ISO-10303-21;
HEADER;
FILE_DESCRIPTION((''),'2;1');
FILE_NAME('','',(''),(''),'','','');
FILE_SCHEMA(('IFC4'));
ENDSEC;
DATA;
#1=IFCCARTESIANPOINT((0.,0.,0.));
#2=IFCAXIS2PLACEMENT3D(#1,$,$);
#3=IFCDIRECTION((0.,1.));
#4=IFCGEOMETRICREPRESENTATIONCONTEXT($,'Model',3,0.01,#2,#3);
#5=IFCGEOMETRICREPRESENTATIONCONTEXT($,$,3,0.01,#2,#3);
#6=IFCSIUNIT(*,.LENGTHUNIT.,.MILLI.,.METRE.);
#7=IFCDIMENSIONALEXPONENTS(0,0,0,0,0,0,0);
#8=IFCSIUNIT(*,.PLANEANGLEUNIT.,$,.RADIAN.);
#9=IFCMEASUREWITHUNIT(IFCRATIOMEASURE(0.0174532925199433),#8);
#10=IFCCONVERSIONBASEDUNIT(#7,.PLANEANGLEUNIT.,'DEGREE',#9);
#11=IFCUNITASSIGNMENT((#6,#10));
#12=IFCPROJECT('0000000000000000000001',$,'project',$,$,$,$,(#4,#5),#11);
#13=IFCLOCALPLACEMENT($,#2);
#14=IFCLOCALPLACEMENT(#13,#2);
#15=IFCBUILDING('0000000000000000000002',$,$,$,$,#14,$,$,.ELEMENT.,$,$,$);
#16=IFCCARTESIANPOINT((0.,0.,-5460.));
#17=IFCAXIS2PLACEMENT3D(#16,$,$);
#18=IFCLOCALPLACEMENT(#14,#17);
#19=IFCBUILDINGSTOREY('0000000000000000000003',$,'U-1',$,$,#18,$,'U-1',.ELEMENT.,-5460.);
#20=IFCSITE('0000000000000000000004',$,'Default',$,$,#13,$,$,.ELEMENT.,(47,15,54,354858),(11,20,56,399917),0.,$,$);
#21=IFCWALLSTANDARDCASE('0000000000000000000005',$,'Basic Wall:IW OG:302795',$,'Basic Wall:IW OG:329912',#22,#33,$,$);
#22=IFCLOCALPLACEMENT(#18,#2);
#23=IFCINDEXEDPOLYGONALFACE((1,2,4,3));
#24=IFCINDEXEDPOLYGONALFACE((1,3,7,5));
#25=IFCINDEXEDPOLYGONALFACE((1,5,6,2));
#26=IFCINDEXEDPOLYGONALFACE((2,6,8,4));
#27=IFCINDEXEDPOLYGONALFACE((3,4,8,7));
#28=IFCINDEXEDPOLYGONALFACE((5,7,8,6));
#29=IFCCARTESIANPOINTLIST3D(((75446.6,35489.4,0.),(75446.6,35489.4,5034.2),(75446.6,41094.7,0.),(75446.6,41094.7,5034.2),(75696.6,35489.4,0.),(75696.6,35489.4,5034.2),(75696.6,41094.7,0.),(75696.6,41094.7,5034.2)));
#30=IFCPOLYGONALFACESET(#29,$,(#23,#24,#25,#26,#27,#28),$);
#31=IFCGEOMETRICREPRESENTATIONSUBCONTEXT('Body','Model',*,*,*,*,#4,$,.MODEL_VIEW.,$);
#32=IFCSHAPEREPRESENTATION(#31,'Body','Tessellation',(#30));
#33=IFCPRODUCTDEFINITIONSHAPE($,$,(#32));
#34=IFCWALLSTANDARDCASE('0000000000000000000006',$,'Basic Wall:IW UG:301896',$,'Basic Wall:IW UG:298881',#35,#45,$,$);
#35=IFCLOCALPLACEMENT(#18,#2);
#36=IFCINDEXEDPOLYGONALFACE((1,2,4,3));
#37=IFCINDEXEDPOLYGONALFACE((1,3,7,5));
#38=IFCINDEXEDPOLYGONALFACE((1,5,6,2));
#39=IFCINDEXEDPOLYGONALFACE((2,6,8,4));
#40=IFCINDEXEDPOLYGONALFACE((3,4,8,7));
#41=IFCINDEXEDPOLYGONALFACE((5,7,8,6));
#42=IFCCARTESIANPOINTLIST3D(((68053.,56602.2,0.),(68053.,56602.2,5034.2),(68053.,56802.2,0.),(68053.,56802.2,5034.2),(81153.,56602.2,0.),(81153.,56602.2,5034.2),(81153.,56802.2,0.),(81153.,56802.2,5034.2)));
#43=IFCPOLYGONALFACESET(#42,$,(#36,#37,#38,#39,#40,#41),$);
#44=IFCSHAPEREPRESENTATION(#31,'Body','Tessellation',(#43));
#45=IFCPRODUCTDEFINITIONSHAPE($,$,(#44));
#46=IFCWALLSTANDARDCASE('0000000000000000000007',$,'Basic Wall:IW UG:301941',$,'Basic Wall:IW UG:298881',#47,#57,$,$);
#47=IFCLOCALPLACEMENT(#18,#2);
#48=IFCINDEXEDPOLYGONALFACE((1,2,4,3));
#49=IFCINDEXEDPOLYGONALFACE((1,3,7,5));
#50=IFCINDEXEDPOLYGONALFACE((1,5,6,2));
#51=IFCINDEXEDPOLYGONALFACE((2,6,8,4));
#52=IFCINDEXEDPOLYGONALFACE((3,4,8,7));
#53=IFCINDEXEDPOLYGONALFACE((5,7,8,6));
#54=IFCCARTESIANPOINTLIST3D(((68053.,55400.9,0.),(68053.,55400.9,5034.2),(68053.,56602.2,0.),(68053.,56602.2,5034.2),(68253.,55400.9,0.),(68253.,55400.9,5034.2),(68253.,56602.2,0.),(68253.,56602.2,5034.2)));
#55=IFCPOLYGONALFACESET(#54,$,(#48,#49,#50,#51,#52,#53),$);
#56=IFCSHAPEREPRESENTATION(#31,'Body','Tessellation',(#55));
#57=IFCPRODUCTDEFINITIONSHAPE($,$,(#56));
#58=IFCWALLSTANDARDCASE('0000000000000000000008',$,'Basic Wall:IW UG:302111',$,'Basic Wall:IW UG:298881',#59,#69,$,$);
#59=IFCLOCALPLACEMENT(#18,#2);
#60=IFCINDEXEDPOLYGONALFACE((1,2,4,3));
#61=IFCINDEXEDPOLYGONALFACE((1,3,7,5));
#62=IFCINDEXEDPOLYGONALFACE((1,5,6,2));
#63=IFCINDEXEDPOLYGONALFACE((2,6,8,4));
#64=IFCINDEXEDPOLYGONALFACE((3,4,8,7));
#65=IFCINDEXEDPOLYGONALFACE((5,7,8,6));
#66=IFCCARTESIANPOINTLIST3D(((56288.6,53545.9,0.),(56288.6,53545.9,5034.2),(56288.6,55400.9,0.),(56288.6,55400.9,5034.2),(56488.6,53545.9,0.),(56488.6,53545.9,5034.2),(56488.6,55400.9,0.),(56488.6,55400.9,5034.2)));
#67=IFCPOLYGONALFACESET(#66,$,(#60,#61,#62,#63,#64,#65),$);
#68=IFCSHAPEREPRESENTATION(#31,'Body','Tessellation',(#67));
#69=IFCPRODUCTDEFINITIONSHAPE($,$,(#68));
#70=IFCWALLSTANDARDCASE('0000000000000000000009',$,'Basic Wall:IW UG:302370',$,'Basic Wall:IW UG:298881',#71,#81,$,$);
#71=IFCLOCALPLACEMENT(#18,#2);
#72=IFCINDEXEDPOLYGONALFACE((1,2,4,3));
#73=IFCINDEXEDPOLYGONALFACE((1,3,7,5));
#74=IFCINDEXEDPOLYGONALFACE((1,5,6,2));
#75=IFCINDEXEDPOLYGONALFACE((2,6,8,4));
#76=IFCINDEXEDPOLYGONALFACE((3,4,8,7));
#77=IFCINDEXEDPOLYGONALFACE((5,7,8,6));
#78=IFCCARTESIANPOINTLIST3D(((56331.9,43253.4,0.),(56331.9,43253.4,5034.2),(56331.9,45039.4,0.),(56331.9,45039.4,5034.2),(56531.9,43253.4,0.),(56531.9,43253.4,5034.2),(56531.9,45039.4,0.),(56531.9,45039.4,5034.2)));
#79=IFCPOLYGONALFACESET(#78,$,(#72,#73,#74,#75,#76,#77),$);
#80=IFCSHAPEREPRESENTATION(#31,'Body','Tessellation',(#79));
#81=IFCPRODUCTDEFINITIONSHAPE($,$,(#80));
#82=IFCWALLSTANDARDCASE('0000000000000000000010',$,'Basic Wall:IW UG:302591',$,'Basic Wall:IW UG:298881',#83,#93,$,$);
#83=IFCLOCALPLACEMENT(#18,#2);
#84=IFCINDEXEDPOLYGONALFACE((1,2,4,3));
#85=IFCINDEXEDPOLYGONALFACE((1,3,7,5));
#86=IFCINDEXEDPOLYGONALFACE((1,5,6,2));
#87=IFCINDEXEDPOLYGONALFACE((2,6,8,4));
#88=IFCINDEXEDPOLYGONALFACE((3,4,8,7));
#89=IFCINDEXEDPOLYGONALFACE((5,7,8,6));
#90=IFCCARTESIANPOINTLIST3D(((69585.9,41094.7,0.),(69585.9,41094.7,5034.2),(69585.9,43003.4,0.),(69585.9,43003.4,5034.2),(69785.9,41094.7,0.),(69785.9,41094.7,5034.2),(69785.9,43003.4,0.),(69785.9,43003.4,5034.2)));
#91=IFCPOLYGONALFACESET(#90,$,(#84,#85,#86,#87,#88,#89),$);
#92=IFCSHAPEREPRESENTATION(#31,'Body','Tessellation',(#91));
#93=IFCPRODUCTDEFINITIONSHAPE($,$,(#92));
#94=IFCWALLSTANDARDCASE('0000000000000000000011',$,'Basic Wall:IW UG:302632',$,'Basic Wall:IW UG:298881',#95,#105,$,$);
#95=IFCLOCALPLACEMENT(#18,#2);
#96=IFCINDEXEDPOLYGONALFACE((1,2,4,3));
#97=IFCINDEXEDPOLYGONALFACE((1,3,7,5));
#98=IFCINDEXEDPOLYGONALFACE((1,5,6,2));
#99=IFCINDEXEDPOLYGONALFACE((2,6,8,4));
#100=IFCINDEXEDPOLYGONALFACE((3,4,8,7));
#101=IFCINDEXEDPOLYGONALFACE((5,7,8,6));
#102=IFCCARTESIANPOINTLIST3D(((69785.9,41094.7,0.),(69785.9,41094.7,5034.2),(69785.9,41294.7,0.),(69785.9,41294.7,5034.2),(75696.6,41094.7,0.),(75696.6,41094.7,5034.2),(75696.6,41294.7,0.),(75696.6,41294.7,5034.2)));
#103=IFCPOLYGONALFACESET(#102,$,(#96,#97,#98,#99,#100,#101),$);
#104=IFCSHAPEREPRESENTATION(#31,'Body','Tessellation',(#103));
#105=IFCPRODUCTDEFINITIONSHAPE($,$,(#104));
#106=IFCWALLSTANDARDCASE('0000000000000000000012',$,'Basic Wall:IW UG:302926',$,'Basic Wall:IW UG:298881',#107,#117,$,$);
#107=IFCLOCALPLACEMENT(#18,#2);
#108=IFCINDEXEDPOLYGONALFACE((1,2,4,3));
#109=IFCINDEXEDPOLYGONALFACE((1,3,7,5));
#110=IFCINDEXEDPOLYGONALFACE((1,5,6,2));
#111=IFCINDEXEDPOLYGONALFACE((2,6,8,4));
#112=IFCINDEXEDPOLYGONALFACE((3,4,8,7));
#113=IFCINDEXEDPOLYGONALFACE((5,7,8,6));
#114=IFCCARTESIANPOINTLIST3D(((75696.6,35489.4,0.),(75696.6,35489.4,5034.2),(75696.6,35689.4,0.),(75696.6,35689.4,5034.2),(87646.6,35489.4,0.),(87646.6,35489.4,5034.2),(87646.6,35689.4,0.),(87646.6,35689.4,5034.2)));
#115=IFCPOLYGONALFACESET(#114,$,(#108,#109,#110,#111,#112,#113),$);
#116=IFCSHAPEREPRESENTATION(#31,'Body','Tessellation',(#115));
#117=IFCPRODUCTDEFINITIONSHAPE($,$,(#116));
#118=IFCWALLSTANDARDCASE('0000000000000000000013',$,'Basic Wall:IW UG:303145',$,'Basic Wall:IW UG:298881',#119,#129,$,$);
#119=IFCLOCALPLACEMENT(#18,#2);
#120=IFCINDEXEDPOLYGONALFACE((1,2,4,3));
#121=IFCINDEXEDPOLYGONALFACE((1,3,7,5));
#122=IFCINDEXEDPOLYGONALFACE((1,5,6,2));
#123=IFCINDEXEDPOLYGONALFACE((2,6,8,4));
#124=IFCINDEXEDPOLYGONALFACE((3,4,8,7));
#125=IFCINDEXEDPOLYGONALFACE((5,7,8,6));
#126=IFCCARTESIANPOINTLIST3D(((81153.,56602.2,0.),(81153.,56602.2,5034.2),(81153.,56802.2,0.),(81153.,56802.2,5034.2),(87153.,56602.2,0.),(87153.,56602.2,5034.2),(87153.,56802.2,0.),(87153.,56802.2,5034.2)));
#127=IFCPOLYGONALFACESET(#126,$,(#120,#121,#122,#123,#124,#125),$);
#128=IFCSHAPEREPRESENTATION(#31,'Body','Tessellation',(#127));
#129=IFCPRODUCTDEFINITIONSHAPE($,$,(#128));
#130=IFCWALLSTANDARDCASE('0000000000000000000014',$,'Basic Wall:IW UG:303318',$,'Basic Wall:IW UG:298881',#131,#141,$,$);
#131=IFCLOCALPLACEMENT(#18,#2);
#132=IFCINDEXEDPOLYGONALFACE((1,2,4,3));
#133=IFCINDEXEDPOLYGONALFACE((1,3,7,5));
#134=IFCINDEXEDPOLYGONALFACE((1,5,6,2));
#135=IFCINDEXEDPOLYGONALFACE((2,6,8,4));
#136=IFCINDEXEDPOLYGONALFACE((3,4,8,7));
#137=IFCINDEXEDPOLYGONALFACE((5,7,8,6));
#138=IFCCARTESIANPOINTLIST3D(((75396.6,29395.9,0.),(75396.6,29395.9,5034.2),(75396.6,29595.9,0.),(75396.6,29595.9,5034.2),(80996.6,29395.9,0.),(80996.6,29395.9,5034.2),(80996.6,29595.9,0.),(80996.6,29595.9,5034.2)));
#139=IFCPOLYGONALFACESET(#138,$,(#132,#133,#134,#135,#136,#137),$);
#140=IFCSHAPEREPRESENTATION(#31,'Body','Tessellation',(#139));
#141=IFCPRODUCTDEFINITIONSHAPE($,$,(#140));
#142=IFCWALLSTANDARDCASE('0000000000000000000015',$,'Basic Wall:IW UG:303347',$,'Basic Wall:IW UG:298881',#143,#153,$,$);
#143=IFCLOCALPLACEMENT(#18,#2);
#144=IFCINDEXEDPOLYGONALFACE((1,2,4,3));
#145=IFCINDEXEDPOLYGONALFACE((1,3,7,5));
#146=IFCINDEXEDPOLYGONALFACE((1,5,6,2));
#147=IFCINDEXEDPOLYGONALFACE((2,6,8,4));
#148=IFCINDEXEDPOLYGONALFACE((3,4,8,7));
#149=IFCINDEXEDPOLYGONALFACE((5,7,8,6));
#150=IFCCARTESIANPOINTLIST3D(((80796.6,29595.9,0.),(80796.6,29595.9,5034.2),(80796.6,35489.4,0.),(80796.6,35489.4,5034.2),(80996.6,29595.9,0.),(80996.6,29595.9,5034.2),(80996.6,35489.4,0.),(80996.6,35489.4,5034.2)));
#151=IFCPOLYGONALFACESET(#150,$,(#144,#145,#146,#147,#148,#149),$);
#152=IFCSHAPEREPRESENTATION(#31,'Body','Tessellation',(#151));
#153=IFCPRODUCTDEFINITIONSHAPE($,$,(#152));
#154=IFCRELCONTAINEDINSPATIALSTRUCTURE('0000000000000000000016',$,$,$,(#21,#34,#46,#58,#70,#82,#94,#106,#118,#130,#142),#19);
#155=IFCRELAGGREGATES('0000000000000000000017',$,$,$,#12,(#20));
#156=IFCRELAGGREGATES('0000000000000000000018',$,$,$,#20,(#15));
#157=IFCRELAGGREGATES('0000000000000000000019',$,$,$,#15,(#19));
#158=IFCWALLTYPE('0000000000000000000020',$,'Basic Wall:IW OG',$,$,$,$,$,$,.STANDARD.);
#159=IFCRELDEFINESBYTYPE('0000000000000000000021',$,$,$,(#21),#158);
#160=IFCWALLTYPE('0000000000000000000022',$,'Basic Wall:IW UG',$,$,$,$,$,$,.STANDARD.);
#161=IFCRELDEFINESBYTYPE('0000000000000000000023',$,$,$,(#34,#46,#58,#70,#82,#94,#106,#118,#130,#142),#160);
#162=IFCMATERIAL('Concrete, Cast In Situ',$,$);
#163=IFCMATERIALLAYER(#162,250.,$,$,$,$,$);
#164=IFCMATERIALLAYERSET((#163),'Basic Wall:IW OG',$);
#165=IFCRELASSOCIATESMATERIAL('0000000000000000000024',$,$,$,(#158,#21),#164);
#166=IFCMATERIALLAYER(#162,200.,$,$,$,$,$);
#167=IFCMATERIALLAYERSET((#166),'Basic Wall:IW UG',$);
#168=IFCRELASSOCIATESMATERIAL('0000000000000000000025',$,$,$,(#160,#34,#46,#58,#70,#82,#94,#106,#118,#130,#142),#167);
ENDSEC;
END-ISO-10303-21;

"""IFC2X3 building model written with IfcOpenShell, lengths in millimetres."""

from ifc_helpers import new_model, entity, si_unit, converted_unit, direction, frame, frame_2d, origin, place, context, subcontext, project, spatial, polyline, rectangle, extrude, clip, bounded_halfspace, material, layer, layer_set, layer_usage, type_object, element, save


model = new_model("IFC2X3")

# Units and contexts
model_context = context("Model", 3, precision=0.01, world=origin(), true_north=direction((0.0, 1.0)))
context_of_model = context(None, 3, precision=0.01, world=origin(), true_north=direction((0.0, 1.0)))
body_context = subcontext(model_context, "Body", "Model", "MODEL_VIEW")
ifc_project = project(units=[si_unit("LENGTHUNIT", "METRE", prefix="MILLI"), converted_unit("PLANEANGLEUNIT", "DEGREE", entity("IfcRatioMeasure", 0.0174532925199433), si_unit("PLANEANGLEUNIT", "RADIAN"), dimensions=[0, 0, 0, 0, 0, 0, 0])], contexts=[model_context, context_of_model])

# Site, building, storey
site_placement = place(None, origin())
site = spatial("IfcSite", under=ifc_project, at=site_placement, Name="Default", CompositionType="ELEMENT", RefLatitude=(47, 15, 54, 354858), RefLongitude=(11, 20, 56, 399917), RefElevation=0.0)
building_placement = place(site_placement, origin())
building = spatial("IfcBuilding", under=site, at=building_placement, CompositionType="ELEMENT")
storey_placement = place(building_placement, frame((0.0, 0.0, -5460.0)))
storey = spatial("IfcBuildingStorey", under=building, at=storey_placement, Name="U-1", LongName="U-1", CompositionType="ELEMENT", Elevation=-5460.0)

# Walls
ifc_material_1 = material(Name="Concrete, Cast In Situ")
ifc_layer_1 = layer(ifc_material_1, 250.0)
ifc_layer_set_1 = layer_set([ifc_layer_1], Name="Basic Wall:IW OG")
wall_type_1 = type_object("IfcWallType", Name="Basic Wall:IW OG", PredefinedType="STANDARD", material=ifc_layer_set_1)
ifc_layer_usage_1 = layer_usage(ifc_layer_set_1, "AXIS2", "NEGATIVE", 125.0)
wall_1_placement = place(storey_placement, frame((75571.6, 41094.7, 0.0), z_axis=(0.0, 0.0, 1.0), x_axis=(0.0, -1.0, 0.0)))
element("IfcWallStandardCase", 1, at=wall_1_placement, inside=storey, type_object=wall_type_1, material=ifc_layer_usage_1, Name="Basic Wall:IW OG:302795", ObjectType="Basic Wall:IW OG:329912", context=body_context, shape_type="Clipping", body=[
    clip(extrude(rectangle(XDim=5605.2, YDim=250.0, at=frame_2d((2802.6, 0.0), x_axis=(-1.0, 0.0))), origin(), (0.0, 0.0, 1.0), 5034.2), bounded_halfspace(frame((0.0, -125.0, 5034.2), z_axis=(0.0, 0.0, -1.0), x_axis=(0.0, 1.0, 0.0)), True, frame((0.0, -125.0, 5034.2)), polyline([(0.0, 0.0), (5605.2, 0.0), (5605.2, 250.0), (5405.2, 250.0), (0.0, 250.0), (0.0, 0.0)]))),
])
ifc_layer_2 = layer(ifc_material_1, 200.0)
ifc_layer_set_2 = layer_set([ifc_layer_2], Name="Basic Wall:IW UG")
ifc_layer_usage_2 = layer_usage(ifc_layer_set_2, "AXIS2", "NEGATIVE", 100.0)
wall_type_2 = type_object("IfcWallType", Name="Basic Wall:IW UG", PredefinedType="STANDARD", material=ifc_layer_set_2)
wall_2_placement = place(storey_placement, frame((81153.0, 56702.2, 0.0), z_axis=(0.0, 0.0, 1.0), x_axis=(-1.0, 0.0, 0.0)))
element("IfcWallStandardCase", 2, at=wall_2_placement, inside=storey, type_object=wall_type_2, material=ifc_layer_usage_2, Name="Basic Wall:IW UG:301896", ObjectType="Basic Wall:IW UG:298881", context=body_context, shape_type="Clipping", body=[
    clip(extrude(rectangle(XDim=13100.0, YDim=200.0, at=frame_2d((6550.0, 0.0), x_axis=(-1.0, 0.0))), origin(), (0.0, 0.0, 1.0), 5034.2), bounded_halfspace(frame((0.0, -100.0, 5034.2), z_axis=(0.0, 0.0, -1.0), x_axis=(-1.0, 0.0, 0.0)), True, frame((0.0, -100.0, 5034.2)), polyline([(0.0, 0.0), (13100.0, 0.0), (13100.0, 200.0), (12900.0, 200.0), (5460.0, 200.0), (0.0, 200.0), (0.0, 0.0)]))),
])
ifc_layer_usage_3 = layer_usage(ifc_layer_set_2, "AXIS2", "NEGATIVE", 100.0)
wall_3_placement = place(storey_placement, frame((68153.0, 56602.2, 0.0), z_axis=(0.0, 0.0, 1.0), x_axis=(0.0, -1.0, 0.0)))
element("IfcWallStandardCase", 3, at=wall_3_placement, inside=storey, type_object=wall_type_2, material=ifc_layer_usage_3, Name="Basic Wall:IW UG:301941", ObjectType="Basic Wall:IW UG:298881", context=body_context, shape_type="Clipping", body=[
    clip(extrude(rectangle(XDim=1201.4, YDim=200.0, at=frame_2d((600.7, 0.0), x_axis=(-1.0, 0.0))), origin(), (0.0, 0.0, 1.0), 5034.2), bounded_halfspace(frame((0.0, -100.0, 5034.2), z_axis=(0.0, 0.0, -1.0), x_axis=(0.0, 1.0, 0.0)), True, frame((0.0, -100.0, 5034.2)), polyline([(0.0, 0.0), (951.4, 0.0), (1201.4, 0.0), (1201.4, 200.0), (0.0, 200.0), (0.0, 0.0)]))),
])
ifc_layer_usage_4 = layer_usage(ifc_layer_set_2, "AXIS2", "NEGATIVE", 100.0)
wall_4_placement = place(storey_placement, frame((56388.6, 55400.9, 0.0), z_axis=(0.0, 0.0, 1.0), x_axis=(0.0, -1.0, 0.0)))
element("IfcWallStandardCase", 4, at=wall_4_placement, inside=storey, type_object=wall_type_2, material=ifc_layer_usage_4, Name="Basic Wall:IW UG:302111", ObjectType="Basic Wall:IW UG:298881", context=body_context, shape_type="Clipping", body=[
    clip(extrude(rectangle(XDim=1855.0, YDim=200.0, at=frame_2d((927.5, 0.0), x_axis=(-1.0, 0.0))), origin(), (0.0, 0.0, 1.0), 5034.2), bounded_halfspace(frame((0.0, -100.0, 5034.2), z_axis=(0.0, 0.0, -1.0), x_axis=(0.0, 1.0, 0.0)), True, frame((0.0, -100.0, 5034.2)), polyline([(0.0, 0.0), (1655.0, 0.0), (1855.0, 0.0), (1855.0, 200.0), (0.0, 200.0), (0.0, 0.0)]))),
])
ifc_layer_usage_5 = layer_usage(ifc_layer_set_2, "AXIS2", "NEGATIVE", 100.0)
wall_5_placement = place(storey_placement, frame((56431.9, 45039.4, 0.0), z_axis=(0.0, 0.0, 1.0), x_axis=(0.0, -1.0, 0.0)))
element("IfcWallStandardCase", 5, at=wall_5_placement, inside=storey, type_object=wall_type_2, material=ifc_layer_usage_5, Name="Basic Wall:IW UG:302370", ObjectType="Basic Wall:IW UG:298881", context=body_context, shape_type="Clipping", body=[
    clip(extrude(rectangle(XDim=1786.0, YDim=200.0, at=frame_2d((893.0, 0.0), x_axis=(-1.0, 0.0))), origin(), (0.0, 0.0, 1.0), 5034.2), bounded_halfspace(frame((0.0, -100.0, 5034.2), z_axis=(0.0, 0.0, -1.0), x_axis=(0.0, 1.0, 0.0)), True, frame((0.0, -100.0, 5034.2)), polyline([(0.0, 0.0), (1786.0, 0.0), (1786.0, 200.0), (0.0, 200.0), (0.0, 0.0)]))),
])
ifc_layer_usage_6 = layer_usage(ifc_layer_set_2, "AXIS2", "NEGATIVE", 100.0)
wall_6_placement = place(storey_placement, frame((69685.9, 43003.4, 0.0), z_axis=(0.0, 0.0, 1.0), x_axis=(0.0, -1.0, 0.0)))
element("IfcWallStandardCase", 6, at=wall_6_placement, inside=storey, type_object=wall_type_2, material=ifc_layer_usage_6, Name="Basic Wall:IW UG:302591", ObjectType="Basic Wall:IW UG:298881", context=body_context, shape_type="Clipping", body=[
    clip(extrude(rectangle(XDim=1908.8, YDim=200.0, at=frame_2d((954.4, 0.0), x_axis=(-1.0, 0.0))), origin(), (0.0, 0.0, 1.0), 5034.2), bounded_halfspace(frame((0.0, -100.0, 5034.2), z_axis=(0.0, 0.0, -1.0), x_axis=(0.0, 1.0, 0.0)), True, frame((0.0, -100.0, 5034.2)), polyline([(0.0, 0.0), (1908.8, 0.0), (1908.8, 200.0), (1708.8, 200.0), (0.0, 200.0), (0.0, 0.0)]))),
])
ifc_layer_usage_7 = layer_usage(ifc_layer_set_2, "AXIS2", "NEGATIVE", 100.0)
wall_7_placement = place(storey_placement, frame((69785.9, 41194.7, 0.0)))
element("IfcWallStandardCase", 7, at=wall_7_placement, inside=storey, type_object=wall_type_2, material=ifc_layer_usage_7, Name="Basic Wall:IW UG:302632", ObjectType="Basic Wall:IW UG:298881", context=body_context, shape_type="Clipping", body=[
    clip(extrude(rectangle(XDim=5910.7, YDim=200.0, at=frame_2d((2955.3, 0.0), x_axis=(-1.0, 0.0))), origin(), (0.0, 0.0, 1.0), 5034.2), bounded_halfspace(frame((0.0, -100.0, 5034.2), z_axis=(0.0, 0.0, -1.0), x_axis=(1.0, 0.0, 0.0)), True, frame((0.0, -100.0, 5034.2)), polyline([(0.0, 0.0), (5660.7, 0.0), (5910.7, 0.0), (5910.7, 200.0), (0.0, 200.0), (0.0, 0.0)]))),
])
ifc_layer_usage_8 = layer_usage(ifc_layer_set_2, "AXIS2", "NEGATIVE", 100.0)
wall_8_placement = place(storey_placement, frame((75696.6, 35589.4, 0.0)))
element("IfcWallStandardCase", 8, at=wall_8_placement, inside=storey, type_object=wall_type_2, material=ifc_layer_usage_8, Name="Basic Wall:IW UG:302926", ObjectType="Basic Wall:IW UG:298881", context=body_context, shape_type="Clipping", body=[
    clip(extrude(rectangle(XDim=11950.0, YDim=200.0, at=frame_2d((5975.0, 0.0), x_axis=(-1.0, 0.0))), origin(), (0.0, 0.0, 1.0), 5034.2), bounded_halfspace(frame((0.0, -100.0, 5034.2), z_axis=(0.0, 0.0, -1.0), x_axis=(1.0, 0.0, 0.0)), True, frame((0.0, -100.0, 5034.2)), polyline([(0.0, 0.0), (5100.0, 0.0), (5300.0, 0.0), (8496.2, 0.0), (8496.2, 200.0), (0.0, 200.0), (0.0, 0.0)]))),
])
ifc_layer_usage_9 = layer_usage(ifc_layer_set_2, "AXIS2", "NEGATIVE", 100.0)
wall_9_placement = place(storey_placement, frame((81153.0, 56702.2, 0.0)))
element("IfcWallStandardCase", 9, at=wall_9_placement, inside=storey, type_object=wall_type_2, material=ifc_layer_usage_9, Name="Basic Wall:IW UG:303145", ObjectType="Basic Wall:IW UG:298881", context=body_context, shape_type="Clipping", body=[
    clip(extrude(rectangle(XDim=6000.0, YDim=200.0, at=frame_2d((3000.0, 0.0), x_axis=(-1.0, 0.0))), origin(), (0.0, 0.0, 1.0), 5034.2), bounded_halfspace(frame((0.0, -100.0, 5034.2), z_axis=(0.0, 0.0, -1.0), x_axis=(1.0, 0.0, 0.0)), True, frame((0.0, -100.0, 5034.2)), polyline([(0.0, 0.0), (5604.8, 0.0), (5604.8, 200.0), (0.0, 200.0), (0.0, 0.0)]))),
])
ifc_layer_usage_10 = layer_usage(ifc_layer_set_2, "AXIS2", "NEGATIVE", 100.0)
wall_10_placement = place(storey_placement, frame((75396.6, 29495.9, 0.0)))
element("IfcWallStandardCase", 10, at=wall_10_placement, inside=storey, type_object=wall_type_2, material=ifc_layer_usage_10, Name="Basic Wall:IW UG:303318", ObjectType="Basic Wall:IW UG:298881", context=body_context, shape_type="Clipping", body=[
    clip(extrude(rectangle(XDim=5600.0, YDim=200.0, at=frame_2d((2800.0, 0.0), x_axis=(-1.0, 0.0))), origin(), (0.0, 0.0, 1.0), 5034.2), bounded_halfspace(frame((0.0, -100.0, 5034.2), z_axis=(0.0, 0.0, -1.0), x_axis=(1.0, 0.0, 0.0)), True, frame((0.0, -100.0, 5034.2)), polyline([(0.0, 0.0), (5600.0, 0.0), (5600.0, 200.0), (5400.0, 200.0), (0.0, 200.0), (0.0, 0.0)]))),
])
ifc_layer_usage_11 = layer_usage(ifc_layer_set_2, "AXIS2", "NEGATIVE", 100.0)
wall_11_placement = place(storey_placement, frame((80896.6, 29595.9, 0.0), z_axis=(0.0, 0.0, 1.0), x_axis=(0.0, 1.0, 0.0)))
element("IfcWallStandardCase", 11, at=wall_11_placement, inside=storey, type_object=wall_type_2, material=ifc_layer_usage_11, Name="Basic Wall:IW UG:303347", ObjectType="Basic Wall:IW UG:298881", context=body_context, shape_type="Clipping", body=[
    clip(extrude(rectangle(XDim=5893.6, YDim=200.0, at=frame_2d((2946.8, 0.0), x_axis=(-1.0, 0.0))), origin(), (0.0, 0.0, 1.0), 5034.2), bounded_halfspace(frame((0.0, -100.0, 5034.2), z_axis=(0.0, 0.0, -1.0), x_axis=(0.0, -1.0, 0.0)), True, frame((0.0, -100.0, 5034.2)), polyline([(0.0, 0.0), (5893.6, 0.0), (5893.6, 200.0), (0.0, 200.0), (0.0, 0.0)]))),
])

save(model, "model.ifc")
